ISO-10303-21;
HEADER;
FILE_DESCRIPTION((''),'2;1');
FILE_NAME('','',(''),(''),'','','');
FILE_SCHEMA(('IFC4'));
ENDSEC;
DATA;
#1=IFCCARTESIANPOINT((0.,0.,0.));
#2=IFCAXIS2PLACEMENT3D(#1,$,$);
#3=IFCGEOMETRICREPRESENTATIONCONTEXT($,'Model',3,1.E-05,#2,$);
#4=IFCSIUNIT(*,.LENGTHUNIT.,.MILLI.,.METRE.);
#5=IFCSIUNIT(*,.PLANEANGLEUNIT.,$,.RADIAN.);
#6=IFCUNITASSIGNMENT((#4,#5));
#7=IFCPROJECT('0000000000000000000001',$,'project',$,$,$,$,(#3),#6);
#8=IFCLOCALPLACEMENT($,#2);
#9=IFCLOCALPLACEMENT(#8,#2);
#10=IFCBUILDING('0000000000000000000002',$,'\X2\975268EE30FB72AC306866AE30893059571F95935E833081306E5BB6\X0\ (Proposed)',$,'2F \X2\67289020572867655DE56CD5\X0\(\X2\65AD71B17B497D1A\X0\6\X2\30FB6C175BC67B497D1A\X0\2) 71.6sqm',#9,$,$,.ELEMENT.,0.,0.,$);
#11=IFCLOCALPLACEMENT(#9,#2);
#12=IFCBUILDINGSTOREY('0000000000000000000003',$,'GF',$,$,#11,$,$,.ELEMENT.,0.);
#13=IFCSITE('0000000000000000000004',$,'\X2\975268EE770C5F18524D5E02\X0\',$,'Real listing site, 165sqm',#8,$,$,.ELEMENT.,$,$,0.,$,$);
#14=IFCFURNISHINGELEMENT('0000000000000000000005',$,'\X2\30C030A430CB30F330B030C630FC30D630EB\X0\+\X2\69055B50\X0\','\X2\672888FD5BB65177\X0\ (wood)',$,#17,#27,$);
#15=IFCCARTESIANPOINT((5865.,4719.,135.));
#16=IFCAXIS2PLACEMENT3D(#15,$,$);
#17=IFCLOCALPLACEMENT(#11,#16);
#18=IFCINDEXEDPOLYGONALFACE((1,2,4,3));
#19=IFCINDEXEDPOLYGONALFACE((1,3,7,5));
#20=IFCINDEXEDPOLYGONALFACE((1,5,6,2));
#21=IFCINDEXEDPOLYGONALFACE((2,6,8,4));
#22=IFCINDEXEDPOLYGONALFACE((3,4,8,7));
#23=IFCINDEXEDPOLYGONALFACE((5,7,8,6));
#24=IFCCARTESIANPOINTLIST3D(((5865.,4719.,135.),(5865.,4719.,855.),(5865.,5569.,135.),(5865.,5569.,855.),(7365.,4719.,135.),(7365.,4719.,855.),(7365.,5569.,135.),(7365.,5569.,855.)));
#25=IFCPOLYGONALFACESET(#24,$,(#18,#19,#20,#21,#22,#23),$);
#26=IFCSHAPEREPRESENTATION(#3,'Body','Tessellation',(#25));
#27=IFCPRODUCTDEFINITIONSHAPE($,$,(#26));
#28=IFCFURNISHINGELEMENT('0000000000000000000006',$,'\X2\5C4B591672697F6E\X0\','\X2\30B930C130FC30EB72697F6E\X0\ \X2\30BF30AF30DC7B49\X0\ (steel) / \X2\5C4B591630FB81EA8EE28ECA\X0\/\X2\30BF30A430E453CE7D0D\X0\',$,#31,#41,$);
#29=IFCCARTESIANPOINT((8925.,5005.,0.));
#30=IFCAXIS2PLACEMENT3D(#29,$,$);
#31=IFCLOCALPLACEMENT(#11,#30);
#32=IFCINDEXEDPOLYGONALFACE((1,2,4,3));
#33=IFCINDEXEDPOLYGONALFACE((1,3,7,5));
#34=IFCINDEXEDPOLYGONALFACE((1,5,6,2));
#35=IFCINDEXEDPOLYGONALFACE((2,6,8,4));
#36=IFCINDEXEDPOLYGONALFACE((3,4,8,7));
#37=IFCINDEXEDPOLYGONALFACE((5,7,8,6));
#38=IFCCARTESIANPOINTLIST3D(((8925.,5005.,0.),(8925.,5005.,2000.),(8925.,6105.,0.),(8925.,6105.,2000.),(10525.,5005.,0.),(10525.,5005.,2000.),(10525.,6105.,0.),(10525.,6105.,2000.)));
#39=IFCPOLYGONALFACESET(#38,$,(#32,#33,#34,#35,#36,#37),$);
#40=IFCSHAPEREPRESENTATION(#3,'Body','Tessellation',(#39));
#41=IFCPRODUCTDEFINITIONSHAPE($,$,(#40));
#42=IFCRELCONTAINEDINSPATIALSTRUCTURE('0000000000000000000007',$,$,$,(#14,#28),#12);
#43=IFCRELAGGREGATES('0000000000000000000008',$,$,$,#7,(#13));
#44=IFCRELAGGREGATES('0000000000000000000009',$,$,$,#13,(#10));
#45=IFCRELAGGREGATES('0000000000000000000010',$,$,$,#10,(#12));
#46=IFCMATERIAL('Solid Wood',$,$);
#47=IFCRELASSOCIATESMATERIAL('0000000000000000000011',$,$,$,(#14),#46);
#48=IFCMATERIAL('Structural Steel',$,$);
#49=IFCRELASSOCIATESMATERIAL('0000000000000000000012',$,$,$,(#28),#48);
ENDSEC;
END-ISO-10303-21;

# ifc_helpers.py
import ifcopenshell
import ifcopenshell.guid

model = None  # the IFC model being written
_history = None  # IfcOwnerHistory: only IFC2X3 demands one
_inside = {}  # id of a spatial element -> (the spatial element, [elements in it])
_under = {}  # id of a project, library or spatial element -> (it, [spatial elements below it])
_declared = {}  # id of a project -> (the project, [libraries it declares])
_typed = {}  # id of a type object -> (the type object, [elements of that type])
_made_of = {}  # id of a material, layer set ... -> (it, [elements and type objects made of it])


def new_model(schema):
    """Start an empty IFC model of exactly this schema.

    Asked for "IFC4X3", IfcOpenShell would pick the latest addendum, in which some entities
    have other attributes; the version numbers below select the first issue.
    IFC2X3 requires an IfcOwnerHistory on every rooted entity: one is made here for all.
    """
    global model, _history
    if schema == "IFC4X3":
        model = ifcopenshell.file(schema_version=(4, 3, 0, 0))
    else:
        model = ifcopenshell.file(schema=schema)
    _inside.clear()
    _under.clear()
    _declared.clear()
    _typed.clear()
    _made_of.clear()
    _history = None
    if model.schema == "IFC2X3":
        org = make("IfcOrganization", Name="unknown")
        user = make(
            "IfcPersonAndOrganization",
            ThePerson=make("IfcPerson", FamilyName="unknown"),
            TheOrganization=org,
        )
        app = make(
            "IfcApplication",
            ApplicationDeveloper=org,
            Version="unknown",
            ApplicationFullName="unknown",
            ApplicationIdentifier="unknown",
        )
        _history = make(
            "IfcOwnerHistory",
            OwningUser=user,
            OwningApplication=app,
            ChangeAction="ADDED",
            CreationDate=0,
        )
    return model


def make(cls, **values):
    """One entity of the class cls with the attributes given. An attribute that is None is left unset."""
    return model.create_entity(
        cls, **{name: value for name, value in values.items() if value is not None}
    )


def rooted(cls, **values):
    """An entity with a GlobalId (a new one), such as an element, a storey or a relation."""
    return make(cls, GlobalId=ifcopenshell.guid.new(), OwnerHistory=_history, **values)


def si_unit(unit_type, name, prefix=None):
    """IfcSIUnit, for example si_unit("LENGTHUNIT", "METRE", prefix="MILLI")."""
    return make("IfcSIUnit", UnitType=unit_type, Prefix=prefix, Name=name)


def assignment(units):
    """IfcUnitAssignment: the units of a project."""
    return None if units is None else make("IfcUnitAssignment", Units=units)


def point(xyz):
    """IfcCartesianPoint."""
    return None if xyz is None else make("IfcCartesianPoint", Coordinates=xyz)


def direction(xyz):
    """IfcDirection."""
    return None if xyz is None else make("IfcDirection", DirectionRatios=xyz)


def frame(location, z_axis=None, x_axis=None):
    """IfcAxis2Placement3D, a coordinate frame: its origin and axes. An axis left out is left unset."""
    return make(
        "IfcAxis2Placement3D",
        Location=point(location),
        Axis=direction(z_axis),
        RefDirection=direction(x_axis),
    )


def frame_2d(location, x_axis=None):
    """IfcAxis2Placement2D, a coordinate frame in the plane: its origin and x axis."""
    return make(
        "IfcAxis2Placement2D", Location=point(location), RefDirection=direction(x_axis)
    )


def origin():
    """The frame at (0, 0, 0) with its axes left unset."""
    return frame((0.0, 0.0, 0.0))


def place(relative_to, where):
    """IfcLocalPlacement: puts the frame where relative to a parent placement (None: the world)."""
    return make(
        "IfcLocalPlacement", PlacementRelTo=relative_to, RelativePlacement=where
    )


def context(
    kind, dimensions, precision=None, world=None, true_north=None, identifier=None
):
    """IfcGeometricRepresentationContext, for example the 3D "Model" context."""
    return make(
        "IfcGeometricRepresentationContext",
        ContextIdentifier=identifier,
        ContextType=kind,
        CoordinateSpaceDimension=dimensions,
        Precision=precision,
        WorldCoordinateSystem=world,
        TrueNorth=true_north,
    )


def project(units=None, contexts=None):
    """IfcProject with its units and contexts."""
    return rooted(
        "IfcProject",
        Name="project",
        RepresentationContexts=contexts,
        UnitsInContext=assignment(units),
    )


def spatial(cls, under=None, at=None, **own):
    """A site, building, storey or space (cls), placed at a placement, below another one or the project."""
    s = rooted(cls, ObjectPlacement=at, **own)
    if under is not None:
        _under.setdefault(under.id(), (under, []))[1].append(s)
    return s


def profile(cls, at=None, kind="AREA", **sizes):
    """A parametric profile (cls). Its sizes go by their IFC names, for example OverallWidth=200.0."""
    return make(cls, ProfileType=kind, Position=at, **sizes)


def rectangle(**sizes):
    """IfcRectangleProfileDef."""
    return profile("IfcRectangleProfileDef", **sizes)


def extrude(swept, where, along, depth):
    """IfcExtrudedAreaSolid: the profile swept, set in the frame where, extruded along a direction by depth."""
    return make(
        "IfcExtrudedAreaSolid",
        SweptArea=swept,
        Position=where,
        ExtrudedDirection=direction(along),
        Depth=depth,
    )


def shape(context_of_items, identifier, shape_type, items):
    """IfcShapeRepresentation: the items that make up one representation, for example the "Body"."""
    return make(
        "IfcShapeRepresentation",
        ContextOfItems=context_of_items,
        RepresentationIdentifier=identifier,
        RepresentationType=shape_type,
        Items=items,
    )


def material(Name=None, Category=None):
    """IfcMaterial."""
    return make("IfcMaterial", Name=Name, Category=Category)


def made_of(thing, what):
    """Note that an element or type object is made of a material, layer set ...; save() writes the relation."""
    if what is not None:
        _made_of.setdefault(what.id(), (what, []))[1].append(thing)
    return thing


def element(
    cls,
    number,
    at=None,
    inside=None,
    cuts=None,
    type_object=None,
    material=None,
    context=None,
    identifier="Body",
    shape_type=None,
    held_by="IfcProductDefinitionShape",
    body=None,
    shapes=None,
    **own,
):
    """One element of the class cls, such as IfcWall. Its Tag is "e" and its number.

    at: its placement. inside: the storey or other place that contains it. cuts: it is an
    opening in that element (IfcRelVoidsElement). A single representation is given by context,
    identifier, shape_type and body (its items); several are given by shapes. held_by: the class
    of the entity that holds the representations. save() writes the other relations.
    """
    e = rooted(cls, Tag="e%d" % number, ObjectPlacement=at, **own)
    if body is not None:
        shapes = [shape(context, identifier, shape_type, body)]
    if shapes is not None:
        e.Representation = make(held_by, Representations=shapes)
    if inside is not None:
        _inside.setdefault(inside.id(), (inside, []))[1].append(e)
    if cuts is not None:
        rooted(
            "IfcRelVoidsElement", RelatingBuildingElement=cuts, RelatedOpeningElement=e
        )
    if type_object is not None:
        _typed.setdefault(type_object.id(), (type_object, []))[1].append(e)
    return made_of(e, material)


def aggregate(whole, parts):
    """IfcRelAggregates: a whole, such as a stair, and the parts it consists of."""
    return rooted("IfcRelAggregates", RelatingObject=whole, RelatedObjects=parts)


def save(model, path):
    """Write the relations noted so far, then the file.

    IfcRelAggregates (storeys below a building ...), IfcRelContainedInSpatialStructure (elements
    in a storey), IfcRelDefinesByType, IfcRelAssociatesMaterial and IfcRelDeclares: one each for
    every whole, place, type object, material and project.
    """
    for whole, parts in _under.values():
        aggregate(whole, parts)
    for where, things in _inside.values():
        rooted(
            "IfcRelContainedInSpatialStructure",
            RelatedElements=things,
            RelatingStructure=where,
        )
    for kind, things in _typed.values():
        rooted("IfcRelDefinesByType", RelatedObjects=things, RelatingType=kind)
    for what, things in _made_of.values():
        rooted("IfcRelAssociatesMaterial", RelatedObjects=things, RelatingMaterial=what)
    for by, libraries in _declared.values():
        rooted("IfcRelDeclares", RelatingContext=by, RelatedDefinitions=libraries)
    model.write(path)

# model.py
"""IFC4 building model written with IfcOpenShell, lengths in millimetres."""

from ifc_helpers import new_model, si_unit, frame, frame_2d, origin, place, context, project, spatial, rectangle, extrude, material, element, save


model = new_model("IFC4")

# Units and contexts
model_context = context("Model", 3, precision=1e-05, world=origin())
ifc_project = project(units=[si_unit("LENGTHUNIT", "METRE", prefix="MILLI"), si_unit("PLANEANGLEUNIT", "RADIAN")], contexts=[model_context])

# Site, building, storey
site_placement = place(None, origin())
site = spatial("IfcSite", under=ifc_project, at=site_placement, Name="青森県弘前市", ObjectType="Real listing site, 165sqm", CompositionType="ELEMENT", RefElevation=0.0)
building_placement = place(site_placement, origin())
building = spatial("IfcBuilding", under=site, at=building_placement, Name="青森・犬と暮らす土間広めの家 (Proposed)", ObjectType="2F 木造在来工法(断熱等級6・気密等級2) 71.6sqm", CompositionType="ELEMENT", ElevationOfRefHeight=0.0, ElevationOfTerrain=0.0)
storey_placement = place(building_placement, origin())
storey = spatial("IfcBuildingStorey", under=building, at=storey_placement, Name="GF", CompositionType="ELEMENT", Elevation=0.0)

# Shared definitions
ifc_material_1 = material(Name="Solid Wood")

# Shared definitions
ifc_material_2 = material(Name="Structural Steel")

# Furnishing elements
furnishing_1_placement = place(storey_placement, frame((5865.0, 4719.0, 135.0)))
element("IfcFurnishingElement", 1, at=furnishing_1_placement, inside=storey, material=ifc_material_1, Name="ダイニングテーブル+椅子", Description="木製家具 (wood)", context=model_context, shape_type="SweptSolid", body=[
    extrude(rectangle(XDim=1500.0, YDim=850.0, at=frame_2d((750.0, 425.0))), frame((5865.0, 4719.0, 135.0)), (0.0, 0.0, 1.0), 720.0),
])
furnishing_2_placement = place(storey_placement, frame((8925.0, 5005.0, 0.0)))
element("IfcFurnishingElement", 2, at=furnishing_2_placement, inside=storey, material=ifc_material_2, Name="屋外物置", Description="スチール物置 タクボ等 (steel) / 屋外・自転車/タイヤ収納", context=model_context, shape_type="SweptSolid", body=[
    extrude(rectangle(XDim=1600.0, YDim=1100.0, at=frame_2d((800.0, 550.0))), frame((8925.0, 5005.0, 0.0)), (0.0, 0.0, 1.0), 2000.0),
])

save(model, "model.ifc")
